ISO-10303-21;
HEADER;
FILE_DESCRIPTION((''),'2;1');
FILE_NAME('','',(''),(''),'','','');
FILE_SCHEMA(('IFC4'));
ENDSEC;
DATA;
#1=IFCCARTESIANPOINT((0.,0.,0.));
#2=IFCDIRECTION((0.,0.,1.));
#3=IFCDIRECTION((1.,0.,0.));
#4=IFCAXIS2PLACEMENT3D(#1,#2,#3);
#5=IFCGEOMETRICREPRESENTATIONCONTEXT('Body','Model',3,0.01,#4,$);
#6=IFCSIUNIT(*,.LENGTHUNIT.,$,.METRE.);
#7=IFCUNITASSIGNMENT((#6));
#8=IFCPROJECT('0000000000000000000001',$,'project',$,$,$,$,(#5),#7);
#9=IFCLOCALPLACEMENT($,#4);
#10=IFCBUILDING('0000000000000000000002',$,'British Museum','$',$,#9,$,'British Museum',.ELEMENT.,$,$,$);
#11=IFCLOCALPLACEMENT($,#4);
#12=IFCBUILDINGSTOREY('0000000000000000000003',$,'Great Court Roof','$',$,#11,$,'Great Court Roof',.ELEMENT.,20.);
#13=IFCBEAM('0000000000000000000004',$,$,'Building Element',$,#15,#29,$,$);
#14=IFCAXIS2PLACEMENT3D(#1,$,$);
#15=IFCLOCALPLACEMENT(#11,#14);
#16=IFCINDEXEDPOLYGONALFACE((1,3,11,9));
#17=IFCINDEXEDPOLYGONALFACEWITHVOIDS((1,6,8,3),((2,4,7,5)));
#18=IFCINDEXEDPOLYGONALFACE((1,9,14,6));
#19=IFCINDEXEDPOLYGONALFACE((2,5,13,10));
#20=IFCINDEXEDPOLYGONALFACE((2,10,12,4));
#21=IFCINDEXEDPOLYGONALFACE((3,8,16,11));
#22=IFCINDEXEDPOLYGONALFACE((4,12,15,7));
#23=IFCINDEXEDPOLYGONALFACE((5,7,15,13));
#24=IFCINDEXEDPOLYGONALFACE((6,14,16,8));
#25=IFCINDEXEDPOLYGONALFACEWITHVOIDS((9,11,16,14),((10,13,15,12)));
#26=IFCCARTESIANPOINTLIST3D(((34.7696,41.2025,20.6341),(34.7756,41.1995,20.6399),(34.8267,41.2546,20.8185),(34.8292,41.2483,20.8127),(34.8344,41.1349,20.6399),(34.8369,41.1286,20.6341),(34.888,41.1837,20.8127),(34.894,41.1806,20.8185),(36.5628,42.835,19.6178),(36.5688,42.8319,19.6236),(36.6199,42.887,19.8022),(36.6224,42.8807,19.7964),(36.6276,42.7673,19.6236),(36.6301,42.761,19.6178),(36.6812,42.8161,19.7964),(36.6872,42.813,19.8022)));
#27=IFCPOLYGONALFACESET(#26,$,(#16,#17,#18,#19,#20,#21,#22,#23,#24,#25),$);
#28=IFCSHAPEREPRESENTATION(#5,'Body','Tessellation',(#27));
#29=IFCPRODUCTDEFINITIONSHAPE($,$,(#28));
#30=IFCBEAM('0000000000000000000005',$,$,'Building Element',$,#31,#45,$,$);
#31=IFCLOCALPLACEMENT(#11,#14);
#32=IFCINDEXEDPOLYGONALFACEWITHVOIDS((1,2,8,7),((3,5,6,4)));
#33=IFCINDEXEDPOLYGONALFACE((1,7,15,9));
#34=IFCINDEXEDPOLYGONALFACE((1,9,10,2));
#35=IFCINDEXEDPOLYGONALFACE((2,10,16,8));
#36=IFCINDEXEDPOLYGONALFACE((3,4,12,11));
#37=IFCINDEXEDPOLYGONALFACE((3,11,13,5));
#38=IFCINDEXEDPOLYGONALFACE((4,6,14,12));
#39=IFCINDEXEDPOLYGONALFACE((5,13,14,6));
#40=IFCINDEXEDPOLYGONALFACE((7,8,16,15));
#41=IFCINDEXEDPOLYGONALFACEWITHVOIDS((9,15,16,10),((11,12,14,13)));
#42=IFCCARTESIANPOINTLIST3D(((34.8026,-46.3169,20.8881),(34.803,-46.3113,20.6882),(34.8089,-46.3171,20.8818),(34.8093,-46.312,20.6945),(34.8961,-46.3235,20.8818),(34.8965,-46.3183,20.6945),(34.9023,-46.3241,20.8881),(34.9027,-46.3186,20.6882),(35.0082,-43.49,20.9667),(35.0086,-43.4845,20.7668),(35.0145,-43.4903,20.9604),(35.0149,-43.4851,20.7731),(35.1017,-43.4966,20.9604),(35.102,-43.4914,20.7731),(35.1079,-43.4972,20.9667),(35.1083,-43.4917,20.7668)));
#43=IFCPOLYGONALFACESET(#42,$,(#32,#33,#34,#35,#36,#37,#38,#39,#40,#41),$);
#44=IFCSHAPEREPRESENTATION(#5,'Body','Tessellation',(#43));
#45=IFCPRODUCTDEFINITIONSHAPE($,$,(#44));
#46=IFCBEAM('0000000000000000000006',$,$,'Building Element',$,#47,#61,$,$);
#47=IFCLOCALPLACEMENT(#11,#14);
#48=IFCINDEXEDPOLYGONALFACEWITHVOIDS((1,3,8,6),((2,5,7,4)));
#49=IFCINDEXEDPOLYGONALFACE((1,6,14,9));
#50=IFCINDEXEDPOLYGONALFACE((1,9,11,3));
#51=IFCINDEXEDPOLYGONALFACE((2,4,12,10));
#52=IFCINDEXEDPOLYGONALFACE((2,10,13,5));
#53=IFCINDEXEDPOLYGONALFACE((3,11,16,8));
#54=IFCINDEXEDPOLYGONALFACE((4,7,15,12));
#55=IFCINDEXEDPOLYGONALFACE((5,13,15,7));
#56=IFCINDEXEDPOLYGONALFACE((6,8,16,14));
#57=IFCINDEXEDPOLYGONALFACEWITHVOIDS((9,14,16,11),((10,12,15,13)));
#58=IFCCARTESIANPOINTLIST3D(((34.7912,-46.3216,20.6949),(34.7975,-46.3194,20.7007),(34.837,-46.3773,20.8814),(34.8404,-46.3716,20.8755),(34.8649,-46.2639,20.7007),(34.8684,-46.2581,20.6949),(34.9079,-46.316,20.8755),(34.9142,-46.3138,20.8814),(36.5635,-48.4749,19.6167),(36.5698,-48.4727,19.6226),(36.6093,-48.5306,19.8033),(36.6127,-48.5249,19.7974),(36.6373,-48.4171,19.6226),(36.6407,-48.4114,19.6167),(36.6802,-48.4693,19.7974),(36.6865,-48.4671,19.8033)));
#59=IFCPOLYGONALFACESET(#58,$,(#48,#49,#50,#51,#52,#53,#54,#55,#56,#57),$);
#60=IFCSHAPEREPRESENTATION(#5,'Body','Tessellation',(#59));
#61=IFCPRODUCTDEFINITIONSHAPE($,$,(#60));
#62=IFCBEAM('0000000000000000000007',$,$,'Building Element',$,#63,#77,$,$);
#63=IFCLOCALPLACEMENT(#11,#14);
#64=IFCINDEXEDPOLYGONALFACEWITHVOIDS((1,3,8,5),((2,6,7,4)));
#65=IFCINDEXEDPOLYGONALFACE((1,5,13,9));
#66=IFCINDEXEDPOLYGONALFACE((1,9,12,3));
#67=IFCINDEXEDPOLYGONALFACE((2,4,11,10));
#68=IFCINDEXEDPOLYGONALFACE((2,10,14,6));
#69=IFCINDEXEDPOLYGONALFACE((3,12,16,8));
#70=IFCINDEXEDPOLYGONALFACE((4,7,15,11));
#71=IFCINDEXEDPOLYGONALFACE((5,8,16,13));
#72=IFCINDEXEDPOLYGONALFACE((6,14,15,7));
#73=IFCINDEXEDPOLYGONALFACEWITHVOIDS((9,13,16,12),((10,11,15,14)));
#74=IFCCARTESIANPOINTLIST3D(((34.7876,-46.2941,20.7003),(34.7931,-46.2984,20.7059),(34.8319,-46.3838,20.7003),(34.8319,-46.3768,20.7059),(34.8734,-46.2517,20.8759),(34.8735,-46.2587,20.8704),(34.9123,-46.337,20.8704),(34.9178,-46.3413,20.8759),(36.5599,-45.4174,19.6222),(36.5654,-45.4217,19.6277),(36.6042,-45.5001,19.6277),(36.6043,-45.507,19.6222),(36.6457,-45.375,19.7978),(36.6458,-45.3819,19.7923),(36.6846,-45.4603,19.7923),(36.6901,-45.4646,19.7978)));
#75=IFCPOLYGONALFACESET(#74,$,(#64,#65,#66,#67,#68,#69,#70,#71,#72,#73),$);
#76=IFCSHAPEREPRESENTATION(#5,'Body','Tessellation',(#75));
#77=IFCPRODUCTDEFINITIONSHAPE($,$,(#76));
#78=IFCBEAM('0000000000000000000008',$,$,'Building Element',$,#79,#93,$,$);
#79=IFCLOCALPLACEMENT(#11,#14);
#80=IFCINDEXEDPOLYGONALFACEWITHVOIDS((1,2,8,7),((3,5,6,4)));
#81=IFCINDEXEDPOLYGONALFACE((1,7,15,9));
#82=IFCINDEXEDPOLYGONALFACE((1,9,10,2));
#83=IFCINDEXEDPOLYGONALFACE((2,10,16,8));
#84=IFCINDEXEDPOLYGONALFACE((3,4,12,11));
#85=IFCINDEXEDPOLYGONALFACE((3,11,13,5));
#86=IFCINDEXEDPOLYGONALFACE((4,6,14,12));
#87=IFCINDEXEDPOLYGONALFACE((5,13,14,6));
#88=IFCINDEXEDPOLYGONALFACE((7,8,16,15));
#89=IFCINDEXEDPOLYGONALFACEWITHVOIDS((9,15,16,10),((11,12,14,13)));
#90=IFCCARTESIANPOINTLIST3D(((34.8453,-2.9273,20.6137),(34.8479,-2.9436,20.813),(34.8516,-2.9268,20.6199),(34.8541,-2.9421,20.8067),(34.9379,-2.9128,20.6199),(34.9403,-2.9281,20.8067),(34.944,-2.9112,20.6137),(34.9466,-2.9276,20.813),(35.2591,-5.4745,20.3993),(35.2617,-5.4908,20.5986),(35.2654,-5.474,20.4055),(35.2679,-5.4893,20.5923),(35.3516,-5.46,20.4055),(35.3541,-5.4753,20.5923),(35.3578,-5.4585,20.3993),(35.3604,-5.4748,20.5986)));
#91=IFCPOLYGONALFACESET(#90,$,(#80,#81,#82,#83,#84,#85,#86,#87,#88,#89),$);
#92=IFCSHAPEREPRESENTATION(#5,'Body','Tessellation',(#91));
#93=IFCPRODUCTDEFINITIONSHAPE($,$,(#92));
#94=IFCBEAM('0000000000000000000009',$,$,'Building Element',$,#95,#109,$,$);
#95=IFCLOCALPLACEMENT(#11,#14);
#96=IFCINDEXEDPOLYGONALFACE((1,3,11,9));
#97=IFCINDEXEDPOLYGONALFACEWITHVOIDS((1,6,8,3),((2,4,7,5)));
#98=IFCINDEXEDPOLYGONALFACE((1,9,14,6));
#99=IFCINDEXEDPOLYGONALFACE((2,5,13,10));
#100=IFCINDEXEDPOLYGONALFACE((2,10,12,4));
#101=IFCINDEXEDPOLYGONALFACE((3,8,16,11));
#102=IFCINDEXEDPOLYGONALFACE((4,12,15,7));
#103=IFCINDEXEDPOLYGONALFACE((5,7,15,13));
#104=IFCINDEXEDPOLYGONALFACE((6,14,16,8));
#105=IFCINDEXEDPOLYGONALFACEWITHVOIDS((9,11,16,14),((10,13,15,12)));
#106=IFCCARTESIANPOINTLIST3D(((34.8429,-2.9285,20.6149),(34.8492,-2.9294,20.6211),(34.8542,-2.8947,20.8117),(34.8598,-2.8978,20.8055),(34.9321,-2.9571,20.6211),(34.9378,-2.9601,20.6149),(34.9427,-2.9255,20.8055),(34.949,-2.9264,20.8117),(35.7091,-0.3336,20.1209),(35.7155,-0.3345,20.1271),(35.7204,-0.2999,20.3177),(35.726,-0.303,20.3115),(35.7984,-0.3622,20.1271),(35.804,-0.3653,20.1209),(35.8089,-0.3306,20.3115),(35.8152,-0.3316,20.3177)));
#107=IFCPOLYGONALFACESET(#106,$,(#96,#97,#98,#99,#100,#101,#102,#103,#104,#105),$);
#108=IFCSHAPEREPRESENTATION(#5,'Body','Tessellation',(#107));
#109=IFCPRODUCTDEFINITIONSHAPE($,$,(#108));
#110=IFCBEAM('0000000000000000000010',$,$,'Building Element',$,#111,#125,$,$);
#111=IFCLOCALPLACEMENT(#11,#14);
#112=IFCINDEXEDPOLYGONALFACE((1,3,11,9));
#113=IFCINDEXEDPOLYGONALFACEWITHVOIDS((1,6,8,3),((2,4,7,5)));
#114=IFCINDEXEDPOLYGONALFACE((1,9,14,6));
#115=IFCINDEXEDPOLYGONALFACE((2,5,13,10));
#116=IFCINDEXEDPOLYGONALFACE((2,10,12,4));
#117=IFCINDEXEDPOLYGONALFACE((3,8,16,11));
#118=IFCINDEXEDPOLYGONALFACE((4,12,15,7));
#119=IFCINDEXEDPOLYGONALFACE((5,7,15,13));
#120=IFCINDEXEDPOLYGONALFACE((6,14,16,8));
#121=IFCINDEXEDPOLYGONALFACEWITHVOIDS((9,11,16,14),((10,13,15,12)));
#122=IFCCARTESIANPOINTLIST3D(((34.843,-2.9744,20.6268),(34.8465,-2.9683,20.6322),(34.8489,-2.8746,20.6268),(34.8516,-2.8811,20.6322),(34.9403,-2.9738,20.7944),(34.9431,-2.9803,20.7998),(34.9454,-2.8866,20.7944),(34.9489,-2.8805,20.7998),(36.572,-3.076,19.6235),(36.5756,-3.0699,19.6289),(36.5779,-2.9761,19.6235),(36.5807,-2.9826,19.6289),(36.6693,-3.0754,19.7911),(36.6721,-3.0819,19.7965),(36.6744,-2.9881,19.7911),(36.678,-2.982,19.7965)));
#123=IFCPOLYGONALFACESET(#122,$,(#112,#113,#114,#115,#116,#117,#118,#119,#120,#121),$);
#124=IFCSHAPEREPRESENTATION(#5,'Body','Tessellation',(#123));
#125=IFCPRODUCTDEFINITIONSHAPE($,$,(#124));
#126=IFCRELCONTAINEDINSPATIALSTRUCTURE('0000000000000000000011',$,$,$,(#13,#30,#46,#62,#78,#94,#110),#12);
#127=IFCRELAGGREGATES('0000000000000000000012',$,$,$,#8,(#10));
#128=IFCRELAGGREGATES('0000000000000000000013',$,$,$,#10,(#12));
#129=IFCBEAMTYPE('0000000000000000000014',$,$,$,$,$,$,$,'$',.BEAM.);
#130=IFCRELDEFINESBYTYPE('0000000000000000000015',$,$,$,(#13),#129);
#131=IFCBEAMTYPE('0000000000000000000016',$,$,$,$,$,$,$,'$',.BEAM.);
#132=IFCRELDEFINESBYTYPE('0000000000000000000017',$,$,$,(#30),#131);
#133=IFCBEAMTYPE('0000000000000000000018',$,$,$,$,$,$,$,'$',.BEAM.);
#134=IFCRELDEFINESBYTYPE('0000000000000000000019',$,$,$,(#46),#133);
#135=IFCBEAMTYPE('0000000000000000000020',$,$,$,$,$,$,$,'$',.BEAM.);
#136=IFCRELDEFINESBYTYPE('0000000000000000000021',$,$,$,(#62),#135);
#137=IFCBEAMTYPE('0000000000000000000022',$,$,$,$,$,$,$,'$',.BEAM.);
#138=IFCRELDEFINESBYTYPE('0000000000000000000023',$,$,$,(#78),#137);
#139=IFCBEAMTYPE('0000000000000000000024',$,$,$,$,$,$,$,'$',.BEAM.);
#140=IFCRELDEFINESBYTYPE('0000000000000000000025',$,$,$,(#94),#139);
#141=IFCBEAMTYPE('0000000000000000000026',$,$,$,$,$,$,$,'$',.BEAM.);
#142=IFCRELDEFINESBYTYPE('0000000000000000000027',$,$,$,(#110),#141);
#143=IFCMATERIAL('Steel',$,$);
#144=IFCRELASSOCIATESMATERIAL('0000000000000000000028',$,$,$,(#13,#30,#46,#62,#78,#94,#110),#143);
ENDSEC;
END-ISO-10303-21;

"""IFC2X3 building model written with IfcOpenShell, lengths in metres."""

from ifc_helpers import new_model, si_unit, frame, origin_with_axes, origin_2d, place, context, project, spatial, hollow_rectangle, extrude, material, type_object, element, save


model = new_model("IFC2X3")

# Units and contexts
model_context = context("Model", 3, precision=0.01, world=origin_with_axes(), identifier="Body")
ifc_project = project(units=[si_unit("LENGTHUNIT", "METRE")], contexts=[model_context])

# Building, storey
building_placement = place(None, origin_with_axes())
building = spatial("IfcBuilding", under=ifc_project, at=building_placement, Name="British Museum", Description="$", LongName="British Museum", CompositionType="ELEMENT")
storey_placement = place(None, origin_with_axes())
storey = spatial("IfcBuildingStorey", under=building, at=storey_placement, Name="Great Court Roof", Description="$", LongName="Great Court Roof", CompositionType="ELEMENT", Elevation=20.0)

# Beams
ifc_material = material(Name="Steel")
beam_type_1 = type_object("IfcBeamType", ElementType="$", PredefinedType="BEAM")
beam_1_placement = place(None, origin_with_axes())
element("IfcBeam", 1, at=beam_1_placement, inside=storey, type_object=beam_type_1, material=ifc_material, Description="Building Element", context=model_context, shape_type="SweptSolid", body=[
    extrude(hollow_rectangle(XDim=0.1, YDim=0.2, WallThickness=0.0063, InnerFilletRadius=0.0, OuterFilletRadius=0.0, at=origin_2d()), frame((34.8318, 41.1916, 20.7263), z_axis=(0.682008, 0.620855, -0.386527), x_axis=(-0.673176, 0.739482, 0.0)), (0.0, 0.0, 1.0), 2.6293),
])
beam_type_2 = type_object("IfcBeamType", ElementType="$", PredefinedType="BEAM")
beam_2_placement = place(None, origin_with_axes())
element("IfcBeam", 2, at=beam_2_placement, inside=storey, type_object=beam_type_2, material=ifc_material, Description="Building Element", context=model_context, shape_type="SweptSolid", body=[
    extrude(hollow_rectangle(XDim=0.1, YDim=0.2, WallThickness=0.0063, InnerFilletRadius=0.0, OuterFilletRadius=0.0, at=origin_2d()), frame((34.8527, -46.3177, 20.7881), z_axis=(0.072508, 0.996982, 0.027728), x_axis=(-0.997366, 0.072536, 0.0)), (0.0, 0.0, 1.0), 2.8354),
])
beam_type_3 = type_object("IfcBeamType", ElementType="$", PredefinedType="BEAM")
beam_3_placement = place(None, origin_with_axes())
element("IfcBeam", 3, at=beam_3_placement, inside=storey, type_object=beam_type_3, material=ifc_material, Description="Building Element", context=model_context, shape_type="SweptSolid", body=[
    extrude(hollow_rectangle(XDim=0.1, YDim=0.2, WallThickness=0.0063, InnerFilletRadius=0.0, OuterFilletRadius=0.0, at=origin_2d()), frame((34.8527, -46.3177, 20.7881), z_axis=(0.592748, -0.720161, -0.360582), x_axis=(0.772102, 0.635499, 0.0)), (0.0, 0.0, 1.0), 2.99),
])
beam_type_4 = type_object("IfcBeamType", ElementType="$", PredefinedType="BEAM")
beam_4_placement = place(None, origin_with_axes())
element("IfcBeam", 4, at=beam_4_placement, inside=storey, type_object=beam_type_4, material=ifc_material, Description="Building Element", context=model_context, shape_type="SweptSolid", body=[
    extrude(hollow_rectangle(XDim=0.1, YDim=0.2, WallThickness=0.0063, InnerFilletRadius=0.0, OuterFilletRadius=0.0, at=origin_2d()), frame((34.8527, -46.3177, 20.7881), z_axis=(0.786949, 0.38928, -0.478719), x_axis=(-0.443387, 0.89633, 0.0)), (0.0, 0.0, 1.0), 2.2521),
])
beam_type_5 = type_object("IfcBeamType", ElementType="$", PredefinedType="BEAM")
beam_5_placement = place(None, origin_with_axes())
element("IfcBeam", 5, at=beam_5_placement, inside=storey, type_object=beam_type_5, material=ifc_material, Description="Building Element", context=model_context, shape_type="SweptSolid", body=[
    extrude(hollow_rectangle(XDim=0.1, YDim=0.2, WallThickness=0.0063, InnerFilletRadius=0.0, OuterFilletRadius=0.0, at=origin_2d()), frame((34.896, -2.9274, 20.7133), z_axis=(0.159793, -0.983672, -0.082797), x_axis=(0.987061, 0.160344, 0.0)), (0.0, 0.0, 1.0), 2.5895),
])
beam_type_6 = type_object("IfcBeamType", ElementType="$", PredefinedType="BEAM")
beam_6_placement = place(None, origin_with_axes())
element("IfcBeam", 6, at=beam_6_placement, inside=storey, type_object=beam_type_6, material=ifc_material, Description="Building Element", context=model_context, shape_type="SweptSolid", body=[
    extrude(hollow_rectangle(XDim=0.1, YDim=0.2, WallThickness=0.0063, InnerFilletRadius=0.0, OuterFilletRadius=0.0, at=origin_2d()), frame((34.896, -2.9274, 20.7133), z_axis=(0.311604, 0.933444, -0.177723), x_axis=(-0.948544, 0.316645, 0.0)), (0.0, 0.0, 1.0), 2.7799),
])
beam_type_7 = type_object("IfcBeamType", ElementType="$", PredefinedType="BEAM")
beam_7_placement = place(None, origin_with_axes())
element("IfcBeam", 7, at=beam_7_placement, inside=storey, type_object=beam_type_7, material=ifc_material, Description="Building Element", context=model_context, shape_type="SweptSolid", body=[
    extrude(hollow_rectangle(XDim=0.1, YDim=0.2, WallThickness=0.0063, InnerFilletRadius=0.0, OuterFilletRadius=0.0, at=origin_2d()), frame((34.896, -2.9274, 20.7133), z_axis=(0.863813, -0.050739, -0.501251), x_axis=(0.058638, 0.998279, 0.0)), (0.0, 0.0, 1.0), 2.0016),
])

save(model, "model.ifc")
